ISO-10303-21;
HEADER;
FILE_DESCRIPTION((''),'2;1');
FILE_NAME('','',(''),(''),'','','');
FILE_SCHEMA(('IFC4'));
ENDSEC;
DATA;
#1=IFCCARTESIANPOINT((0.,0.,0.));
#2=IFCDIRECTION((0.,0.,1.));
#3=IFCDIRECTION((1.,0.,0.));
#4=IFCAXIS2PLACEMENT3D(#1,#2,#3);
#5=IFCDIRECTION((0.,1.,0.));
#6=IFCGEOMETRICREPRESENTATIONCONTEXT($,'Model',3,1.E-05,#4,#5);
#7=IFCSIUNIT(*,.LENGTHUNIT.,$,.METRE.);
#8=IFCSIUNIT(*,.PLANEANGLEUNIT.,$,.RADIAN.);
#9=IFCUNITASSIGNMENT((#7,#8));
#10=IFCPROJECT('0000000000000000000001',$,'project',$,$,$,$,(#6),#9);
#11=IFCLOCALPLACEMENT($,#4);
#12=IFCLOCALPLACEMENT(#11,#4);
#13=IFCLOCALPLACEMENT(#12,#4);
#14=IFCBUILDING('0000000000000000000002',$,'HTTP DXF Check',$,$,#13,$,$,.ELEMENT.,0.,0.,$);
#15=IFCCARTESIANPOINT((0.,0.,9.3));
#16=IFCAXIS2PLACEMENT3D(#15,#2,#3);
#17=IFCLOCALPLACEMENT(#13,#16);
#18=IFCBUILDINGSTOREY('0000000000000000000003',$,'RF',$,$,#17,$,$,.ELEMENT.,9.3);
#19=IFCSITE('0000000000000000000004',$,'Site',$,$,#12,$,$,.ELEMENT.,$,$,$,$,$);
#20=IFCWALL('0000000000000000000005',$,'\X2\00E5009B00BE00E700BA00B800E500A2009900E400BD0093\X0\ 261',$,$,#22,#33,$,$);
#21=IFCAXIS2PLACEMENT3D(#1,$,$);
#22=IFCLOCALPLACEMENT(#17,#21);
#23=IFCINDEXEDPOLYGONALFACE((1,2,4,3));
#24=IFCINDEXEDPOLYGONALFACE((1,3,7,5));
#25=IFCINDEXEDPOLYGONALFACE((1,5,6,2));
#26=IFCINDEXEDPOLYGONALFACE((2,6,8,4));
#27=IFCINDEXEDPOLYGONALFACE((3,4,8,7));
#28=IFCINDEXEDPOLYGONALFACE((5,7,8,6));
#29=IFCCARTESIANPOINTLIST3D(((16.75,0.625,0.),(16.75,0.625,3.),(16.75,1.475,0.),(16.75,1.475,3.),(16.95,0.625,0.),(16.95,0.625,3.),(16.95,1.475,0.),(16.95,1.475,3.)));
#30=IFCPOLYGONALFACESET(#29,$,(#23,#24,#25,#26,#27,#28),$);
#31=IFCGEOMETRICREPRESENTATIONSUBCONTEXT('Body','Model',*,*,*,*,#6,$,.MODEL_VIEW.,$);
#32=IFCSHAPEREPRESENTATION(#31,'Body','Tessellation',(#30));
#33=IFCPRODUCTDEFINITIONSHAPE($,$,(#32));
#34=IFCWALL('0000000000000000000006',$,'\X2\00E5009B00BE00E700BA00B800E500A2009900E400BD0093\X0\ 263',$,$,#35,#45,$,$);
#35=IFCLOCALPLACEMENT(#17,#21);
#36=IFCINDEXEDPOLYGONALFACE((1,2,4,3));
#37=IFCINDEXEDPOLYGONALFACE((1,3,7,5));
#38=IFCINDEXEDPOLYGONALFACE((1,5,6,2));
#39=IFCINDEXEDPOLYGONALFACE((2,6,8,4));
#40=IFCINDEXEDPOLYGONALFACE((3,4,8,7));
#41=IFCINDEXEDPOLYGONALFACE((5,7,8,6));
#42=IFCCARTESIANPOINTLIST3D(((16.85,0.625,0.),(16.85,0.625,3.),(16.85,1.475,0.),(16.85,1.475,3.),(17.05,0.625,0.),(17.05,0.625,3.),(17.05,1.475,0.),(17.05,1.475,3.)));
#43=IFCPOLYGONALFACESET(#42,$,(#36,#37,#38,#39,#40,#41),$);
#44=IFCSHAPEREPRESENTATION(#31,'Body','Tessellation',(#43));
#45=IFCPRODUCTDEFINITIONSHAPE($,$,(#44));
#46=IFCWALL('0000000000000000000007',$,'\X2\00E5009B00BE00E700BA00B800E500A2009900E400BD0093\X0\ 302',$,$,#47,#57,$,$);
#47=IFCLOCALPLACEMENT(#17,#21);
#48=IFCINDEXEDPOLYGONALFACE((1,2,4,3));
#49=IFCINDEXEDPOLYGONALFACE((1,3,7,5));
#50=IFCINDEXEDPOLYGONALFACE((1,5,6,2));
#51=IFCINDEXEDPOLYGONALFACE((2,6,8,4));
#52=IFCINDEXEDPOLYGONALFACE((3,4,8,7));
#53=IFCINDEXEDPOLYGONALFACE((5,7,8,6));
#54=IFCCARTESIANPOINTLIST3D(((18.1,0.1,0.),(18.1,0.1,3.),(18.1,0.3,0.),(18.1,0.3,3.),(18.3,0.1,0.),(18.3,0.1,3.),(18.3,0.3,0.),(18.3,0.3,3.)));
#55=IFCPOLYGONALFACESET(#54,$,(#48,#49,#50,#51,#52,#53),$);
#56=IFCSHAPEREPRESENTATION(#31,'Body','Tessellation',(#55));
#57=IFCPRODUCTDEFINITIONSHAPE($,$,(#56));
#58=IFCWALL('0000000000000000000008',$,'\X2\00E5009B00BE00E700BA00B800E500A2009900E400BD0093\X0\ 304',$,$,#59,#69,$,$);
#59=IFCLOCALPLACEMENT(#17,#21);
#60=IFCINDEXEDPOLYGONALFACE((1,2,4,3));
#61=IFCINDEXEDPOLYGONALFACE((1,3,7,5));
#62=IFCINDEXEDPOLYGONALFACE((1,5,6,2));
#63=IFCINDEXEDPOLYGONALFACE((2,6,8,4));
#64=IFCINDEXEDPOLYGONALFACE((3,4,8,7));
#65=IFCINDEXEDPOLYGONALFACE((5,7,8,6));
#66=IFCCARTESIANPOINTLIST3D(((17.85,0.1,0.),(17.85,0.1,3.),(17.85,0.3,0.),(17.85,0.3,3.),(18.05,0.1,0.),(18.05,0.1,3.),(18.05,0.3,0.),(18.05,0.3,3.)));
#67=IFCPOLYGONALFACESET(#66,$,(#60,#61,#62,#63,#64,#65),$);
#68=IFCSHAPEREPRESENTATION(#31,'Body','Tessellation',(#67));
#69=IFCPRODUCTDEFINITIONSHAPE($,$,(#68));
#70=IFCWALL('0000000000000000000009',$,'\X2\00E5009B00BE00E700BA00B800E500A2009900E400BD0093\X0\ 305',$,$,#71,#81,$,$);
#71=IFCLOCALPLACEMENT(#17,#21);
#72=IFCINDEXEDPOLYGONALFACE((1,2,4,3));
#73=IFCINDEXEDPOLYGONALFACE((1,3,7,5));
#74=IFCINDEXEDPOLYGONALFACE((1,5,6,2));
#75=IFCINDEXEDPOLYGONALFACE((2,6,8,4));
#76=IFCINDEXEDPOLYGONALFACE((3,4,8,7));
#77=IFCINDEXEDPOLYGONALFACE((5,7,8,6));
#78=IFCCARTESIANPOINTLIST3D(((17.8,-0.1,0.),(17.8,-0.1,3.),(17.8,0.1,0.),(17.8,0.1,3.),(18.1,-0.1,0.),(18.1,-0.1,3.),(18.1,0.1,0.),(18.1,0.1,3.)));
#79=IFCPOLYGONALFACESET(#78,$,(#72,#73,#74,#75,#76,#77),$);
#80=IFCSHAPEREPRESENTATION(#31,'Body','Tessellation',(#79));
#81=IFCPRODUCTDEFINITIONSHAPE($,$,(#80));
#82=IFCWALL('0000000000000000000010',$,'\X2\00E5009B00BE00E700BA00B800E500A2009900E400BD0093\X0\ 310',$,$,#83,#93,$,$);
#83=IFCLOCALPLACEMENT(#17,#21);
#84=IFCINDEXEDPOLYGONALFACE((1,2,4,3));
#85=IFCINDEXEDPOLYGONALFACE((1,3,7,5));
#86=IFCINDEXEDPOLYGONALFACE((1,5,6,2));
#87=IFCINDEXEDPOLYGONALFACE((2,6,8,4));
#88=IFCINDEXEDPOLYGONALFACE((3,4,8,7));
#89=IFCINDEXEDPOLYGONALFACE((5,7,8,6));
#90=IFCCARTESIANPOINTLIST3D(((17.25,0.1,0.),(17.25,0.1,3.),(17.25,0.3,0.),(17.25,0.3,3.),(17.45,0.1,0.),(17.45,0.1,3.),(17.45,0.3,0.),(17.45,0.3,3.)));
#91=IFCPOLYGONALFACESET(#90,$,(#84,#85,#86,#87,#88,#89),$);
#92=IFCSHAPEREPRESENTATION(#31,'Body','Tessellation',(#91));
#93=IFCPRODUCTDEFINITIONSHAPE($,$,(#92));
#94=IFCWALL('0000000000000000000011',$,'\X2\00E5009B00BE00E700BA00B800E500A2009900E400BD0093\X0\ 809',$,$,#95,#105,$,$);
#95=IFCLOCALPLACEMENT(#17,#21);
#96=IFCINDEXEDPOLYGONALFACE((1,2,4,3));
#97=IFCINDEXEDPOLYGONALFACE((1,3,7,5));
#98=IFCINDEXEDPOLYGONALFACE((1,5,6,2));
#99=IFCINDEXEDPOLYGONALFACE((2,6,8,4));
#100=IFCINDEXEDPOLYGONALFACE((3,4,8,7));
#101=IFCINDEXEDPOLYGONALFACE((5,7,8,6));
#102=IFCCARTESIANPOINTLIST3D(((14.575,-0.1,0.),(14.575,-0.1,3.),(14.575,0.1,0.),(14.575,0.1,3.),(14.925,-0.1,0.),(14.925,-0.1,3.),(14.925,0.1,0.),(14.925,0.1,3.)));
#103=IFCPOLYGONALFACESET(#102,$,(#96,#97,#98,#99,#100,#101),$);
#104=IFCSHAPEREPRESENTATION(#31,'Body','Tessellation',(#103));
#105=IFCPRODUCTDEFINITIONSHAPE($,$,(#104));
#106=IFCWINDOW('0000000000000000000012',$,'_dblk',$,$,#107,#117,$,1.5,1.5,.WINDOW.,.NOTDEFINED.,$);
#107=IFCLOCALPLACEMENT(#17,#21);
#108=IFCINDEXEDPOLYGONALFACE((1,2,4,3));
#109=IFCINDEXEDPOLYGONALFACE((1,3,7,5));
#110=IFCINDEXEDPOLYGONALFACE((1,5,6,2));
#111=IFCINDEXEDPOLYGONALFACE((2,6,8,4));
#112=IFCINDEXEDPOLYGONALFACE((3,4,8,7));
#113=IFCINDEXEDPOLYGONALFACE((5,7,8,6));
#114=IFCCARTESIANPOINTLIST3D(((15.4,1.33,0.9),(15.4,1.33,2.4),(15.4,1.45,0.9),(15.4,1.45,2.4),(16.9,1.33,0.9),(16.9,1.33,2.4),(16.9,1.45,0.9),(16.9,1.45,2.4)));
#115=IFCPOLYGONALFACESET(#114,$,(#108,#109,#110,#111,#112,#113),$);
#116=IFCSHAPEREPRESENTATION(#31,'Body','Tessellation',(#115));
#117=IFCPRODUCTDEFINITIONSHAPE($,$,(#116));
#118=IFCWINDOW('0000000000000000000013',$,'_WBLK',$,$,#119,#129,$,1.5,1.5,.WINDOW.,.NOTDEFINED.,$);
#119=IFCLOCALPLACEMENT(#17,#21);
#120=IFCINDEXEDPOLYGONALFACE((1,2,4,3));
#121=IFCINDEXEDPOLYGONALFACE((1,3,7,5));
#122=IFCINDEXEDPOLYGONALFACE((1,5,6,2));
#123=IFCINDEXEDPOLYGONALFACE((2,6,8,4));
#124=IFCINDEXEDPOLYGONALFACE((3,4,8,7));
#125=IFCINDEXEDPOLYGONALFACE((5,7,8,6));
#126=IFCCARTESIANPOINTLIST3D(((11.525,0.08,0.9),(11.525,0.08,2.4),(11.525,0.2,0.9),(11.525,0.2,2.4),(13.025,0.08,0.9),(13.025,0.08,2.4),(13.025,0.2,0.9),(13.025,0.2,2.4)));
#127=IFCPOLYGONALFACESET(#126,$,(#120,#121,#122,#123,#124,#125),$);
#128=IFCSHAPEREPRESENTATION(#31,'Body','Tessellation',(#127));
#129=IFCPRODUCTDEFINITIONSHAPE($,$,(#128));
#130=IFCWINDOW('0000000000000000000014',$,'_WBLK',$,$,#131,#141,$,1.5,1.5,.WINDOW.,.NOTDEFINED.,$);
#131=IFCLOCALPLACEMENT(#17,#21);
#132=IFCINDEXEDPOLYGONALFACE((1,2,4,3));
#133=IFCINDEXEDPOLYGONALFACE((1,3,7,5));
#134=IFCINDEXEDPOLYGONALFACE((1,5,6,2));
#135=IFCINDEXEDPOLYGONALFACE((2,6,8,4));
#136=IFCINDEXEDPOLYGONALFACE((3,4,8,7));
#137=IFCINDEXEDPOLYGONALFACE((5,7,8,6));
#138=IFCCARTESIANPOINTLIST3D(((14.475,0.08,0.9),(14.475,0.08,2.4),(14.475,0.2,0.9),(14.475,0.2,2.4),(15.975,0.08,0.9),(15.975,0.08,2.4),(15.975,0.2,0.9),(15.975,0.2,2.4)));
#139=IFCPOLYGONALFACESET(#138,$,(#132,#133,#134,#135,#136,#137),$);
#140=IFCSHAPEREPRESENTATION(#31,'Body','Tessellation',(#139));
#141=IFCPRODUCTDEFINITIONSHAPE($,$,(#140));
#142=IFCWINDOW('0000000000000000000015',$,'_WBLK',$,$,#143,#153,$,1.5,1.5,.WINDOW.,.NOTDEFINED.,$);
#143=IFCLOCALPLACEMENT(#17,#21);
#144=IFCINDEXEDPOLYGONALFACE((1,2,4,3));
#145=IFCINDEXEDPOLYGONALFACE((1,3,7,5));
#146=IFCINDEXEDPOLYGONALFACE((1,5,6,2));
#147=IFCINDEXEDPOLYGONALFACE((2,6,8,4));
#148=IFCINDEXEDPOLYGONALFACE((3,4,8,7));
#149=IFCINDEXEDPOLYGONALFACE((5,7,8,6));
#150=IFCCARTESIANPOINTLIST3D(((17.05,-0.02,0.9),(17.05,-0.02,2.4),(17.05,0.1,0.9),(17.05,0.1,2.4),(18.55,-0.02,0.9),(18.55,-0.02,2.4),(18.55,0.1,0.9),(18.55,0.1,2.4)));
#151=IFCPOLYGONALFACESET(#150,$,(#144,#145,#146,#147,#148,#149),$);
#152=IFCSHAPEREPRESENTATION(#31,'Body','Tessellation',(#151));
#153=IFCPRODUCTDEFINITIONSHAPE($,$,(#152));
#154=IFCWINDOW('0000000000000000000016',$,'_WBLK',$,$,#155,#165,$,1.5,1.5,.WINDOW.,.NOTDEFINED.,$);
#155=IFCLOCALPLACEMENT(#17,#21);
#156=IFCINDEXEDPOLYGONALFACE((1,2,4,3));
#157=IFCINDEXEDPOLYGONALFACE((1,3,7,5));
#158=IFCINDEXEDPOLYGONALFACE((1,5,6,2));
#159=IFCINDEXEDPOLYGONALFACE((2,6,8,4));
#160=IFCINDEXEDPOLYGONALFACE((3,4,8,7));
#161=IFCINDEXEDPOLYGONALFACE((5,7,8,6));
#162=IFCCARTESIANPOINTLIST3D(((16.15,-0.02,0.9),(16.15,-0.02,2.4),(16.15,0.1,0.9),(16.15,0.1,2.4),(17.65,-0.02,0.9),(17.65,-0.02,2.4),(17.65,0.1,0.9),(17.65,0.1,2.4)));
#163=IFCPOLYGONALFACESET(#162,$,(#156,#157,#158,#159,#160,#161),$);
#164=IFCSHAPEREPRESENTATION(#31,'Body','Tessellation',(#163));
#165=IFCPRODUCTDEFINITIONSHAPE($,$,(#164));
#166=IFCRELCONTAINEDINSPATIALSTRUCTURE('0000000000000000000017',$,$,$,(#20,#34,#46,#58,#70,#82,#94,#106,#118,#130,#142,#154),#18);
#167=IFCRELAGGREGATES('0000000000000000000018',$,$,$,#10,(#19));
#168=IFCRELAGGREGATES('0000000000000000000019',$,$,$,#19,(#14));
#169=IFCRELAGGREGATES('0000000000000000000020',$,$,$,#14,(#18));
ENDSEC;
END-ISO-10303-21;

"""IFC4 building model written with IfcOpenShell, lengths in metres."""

from ifc_helpers import new_model, si_unit, direction, frame, frame_2d, origin_with_axes, place, context, subcontext, project, spatial, rectangle, extrude, element, save


model = new_model("IFC4")

# Units and contexts
model_context = context("Model", 3, precision=1e-05, world=origin_with_axes(), true_north=direction((0.0, 1.0, 0.0)))
body_context = subcontext(model_context, "Body", "Model", "MODEL_VIEW")
ifc_project = project(units=[si_unit("LENGTHUNIT", "METRE"), si_unit("PLANEANGLEUNIT", "RADIAN")], contexts=[model_context])

# Site, building, storey
placement = place(None, origin_with_axes())
site_placement = place(placement, origin_with_axes())
site = spatial("IfcSite", under=ifc_project, at=site_placement, Name="Site", CompositionType="ELEMENT")
building_placement = place(site_placement, origin_with_axes())
building = spatial("IfcBuilding", under=site, at=building_placement, Name="HTTP DXF Check", CompositionType="ELEMENT", ElevationOfRefHeight=0.0, ElevationOfTerrain=0.0)
storey_placement = place(building_placement, frame((0.0, 0.0, 9.3), z_axis=(0.0, 0.0, 1.0), x_axis=(1.0, 0.0, 0.0)))
storey = spatial("IfcBuildingStorey", under=building, at=storey_placement, Name="RF", CompositionType="ELEMENT", Elevation=9.3)

# Walls
for number, where, z_axis, x_axis, name in (
    (1, (16.85, 1.05, 0.0), (0.0, 0.0, 1.0), (0.0, -1.0, 0.0), "å\u009b¾çº¸å¢\u0099ä½\u0093 261"),
    (2, (16.95, 1.05, 0.0), (0.0, 0.0, 1.0), (0.0, -1.0, 0.0), "å\u009b¾çº¸å¢\u0099ä½\u0093 263"),
):
    element("IfcWall", number, at=place(storey_placement, frame(where, z_axis=z_axis, x_axis=x_axis)), inside=storey, Name=name, context=body_context, shape_type="SweptSolid", body=[
        extrude(rectangle(XDim=0.85, YDim=0.2, at=frame_2d((0.0, 0.0), x_axis=(1.0, 0.0, 0.0))), frame((0.0, 0.0, 0.0), z_axis=(0.0, 0.0, 1.0)), (0.0, 0.0, 1.0), 3.0),
    ])
for number, where, z_axis, x_axis, name in (
    (3, (18.2, 0.2, 0.0), (0.0, 0.0, 1.0), (1.0, 0.0, 0.0), "å\u009b¾çº¸å¢\u0099ä½\u0093 302"),
    (4, (17.95, 0.2, 0.0), (0.0, 0.0, 1.0), (1.0, 0.0, 0.0), "å\u009b¾çº¸å¢\u0099ä½\u0093 304"),
):
    element("IfcWall", number, at=place(storey_placement, frame(where, z_axis=z_axis, x_axis=x_axis)), inside=storey, Name=name, context=body_context, shape_type="SweptSolid", body=[
        extrude(rectangle(XDim=0.2, YDim=0.2, at=frame_2d((0.0, 0.0), x_axis=(1.0, 0.0, 0.0))), frame((0.0, 0.0, 0.0), z_axis=(0.0, 0.0, 1.0)), (0.0, 0.0, 1.0), 3.0),
    ])
wall_1_placement = place(storey_placement, frame((17.95, 0.0, 0.0), z_axis=(0.0, 0.0, 1.0), x_axis=(1.0, 0.0, 0.0)))
element("IfcWall", 5, at=wall_1_placement, inside=storey, Name="å\u009b¾çº¸å¢\u0099ä½\u0093 305", context=body_context, shape_type="SweptSolid", body=[
    extrude(rectangle(XDim=0.3, YDim=0.2, at=frame_2d((0.0, 0.0), x_axis=(1.0, 0.0, 0.0))), frame((0.0, 0.0, 0.0), z_axis=(0.0, 0.0, 1.0)), (0.0, 0.0, 1.0), 3.0),
])
for number, where, z_axis, x_axis, name in (
    (6, (17.35, 0.2, 0.0), (0.0, 0.0, 1.0), (0.0, -1.0, 0.0), "å\u009b¾çº¸å¢\u0099ä½\u0093 310"),
):
    element("IfcWall", number, at=place(storey_placement, frame(where, z_axis=z_axis, x_axis=x_axis)), inside=storey, Name=name, context=body_context, shape_type="SweptSolid", body=[
        extrude(rectangle(XDim=0.2, YDim=0.2, at=frame_2d((0.0, 0.0), x_axis=(1.0, 0.0, 0.0))), frame((0.0, 0.0, 0.0), z_axis=(0.0, 0.0, 1.0)), (0.0, 0.0, 1.0), 3.0),
    ])
wall_2_placement = place(storey_placement, frame((14.75, 0.0, 0.0), z_axis=(0.0, 0.0, 1.0), x_axis=(1.0, 0.0, 0.0)))
element("IfcWall", 7, at=wall_2_placement, inside=storey, Name="å\u009b¾çº¸å¢\u0099ä½\u0093 809", context=body_context, shape_type="SweptSolid", body=[
    extrude(rectangle(XDim=0.35, YDim=0.2, at=frame_2d((0.0, 0.0), x_axis=(1.0, 0.0, 0.0))), frame((0.0, 0.0, 0.0), z_axis=(0.0, 0.0, 1.0)), (0.0, 0.0, 1.0), 3.0),
])

# Windows
for number, where, z_axis, x_axis, name in (
    (8, (16.15, 1.39, 0.9), (0.0, 0.0, 1.0), (1.0, 0.0, 0.0), "_dblk"),
    (9, (12.275, 0.14, 0.9), (0.0, 0.0, 1.0), (1.0, 0.0, 0.0), "_WBLK"),
    (10, (15.225, 0.14, 0.9), (0.0, 0.0, 1.0), (1.0, 0.0, 0.0), "_WBLK"),
    (11, (17.8, 0.04, 0.9), (0.0, 0.0, 1.0), (1.0, 0.0, 0.0), "_WBLK"),
    (12, (16.9, 0.04, 0.9), (0.0, 0.0, 1.0), (1.0, 0.0, 0.0), "_WBLK"),
):
    element("IfcWindow", number, at=place(storey_placement, frame(where, z_axis=z_axis, x_axis=x_axis)), inside=storey, Name=name, OverallHeight=1.5, OverallWidth=1.5, PartitioningType="NOTDEFINED", PredefinedType="WINDOW", context=body_context, shape_type="SweptSolid", body=[
        extrude(rectangle(XDim=1.5, YDim=0.12, at=frame_2d((0.0, 0.0), x_axis=(1.0, 0.0, 0.0))), frame((0.0, 0.0, 0.0), z_axis=(0.0, 0.0, 1.0)), (0.0, 0.0, 1.0), 1.5),
    ])

save(model, "model.ifc")
